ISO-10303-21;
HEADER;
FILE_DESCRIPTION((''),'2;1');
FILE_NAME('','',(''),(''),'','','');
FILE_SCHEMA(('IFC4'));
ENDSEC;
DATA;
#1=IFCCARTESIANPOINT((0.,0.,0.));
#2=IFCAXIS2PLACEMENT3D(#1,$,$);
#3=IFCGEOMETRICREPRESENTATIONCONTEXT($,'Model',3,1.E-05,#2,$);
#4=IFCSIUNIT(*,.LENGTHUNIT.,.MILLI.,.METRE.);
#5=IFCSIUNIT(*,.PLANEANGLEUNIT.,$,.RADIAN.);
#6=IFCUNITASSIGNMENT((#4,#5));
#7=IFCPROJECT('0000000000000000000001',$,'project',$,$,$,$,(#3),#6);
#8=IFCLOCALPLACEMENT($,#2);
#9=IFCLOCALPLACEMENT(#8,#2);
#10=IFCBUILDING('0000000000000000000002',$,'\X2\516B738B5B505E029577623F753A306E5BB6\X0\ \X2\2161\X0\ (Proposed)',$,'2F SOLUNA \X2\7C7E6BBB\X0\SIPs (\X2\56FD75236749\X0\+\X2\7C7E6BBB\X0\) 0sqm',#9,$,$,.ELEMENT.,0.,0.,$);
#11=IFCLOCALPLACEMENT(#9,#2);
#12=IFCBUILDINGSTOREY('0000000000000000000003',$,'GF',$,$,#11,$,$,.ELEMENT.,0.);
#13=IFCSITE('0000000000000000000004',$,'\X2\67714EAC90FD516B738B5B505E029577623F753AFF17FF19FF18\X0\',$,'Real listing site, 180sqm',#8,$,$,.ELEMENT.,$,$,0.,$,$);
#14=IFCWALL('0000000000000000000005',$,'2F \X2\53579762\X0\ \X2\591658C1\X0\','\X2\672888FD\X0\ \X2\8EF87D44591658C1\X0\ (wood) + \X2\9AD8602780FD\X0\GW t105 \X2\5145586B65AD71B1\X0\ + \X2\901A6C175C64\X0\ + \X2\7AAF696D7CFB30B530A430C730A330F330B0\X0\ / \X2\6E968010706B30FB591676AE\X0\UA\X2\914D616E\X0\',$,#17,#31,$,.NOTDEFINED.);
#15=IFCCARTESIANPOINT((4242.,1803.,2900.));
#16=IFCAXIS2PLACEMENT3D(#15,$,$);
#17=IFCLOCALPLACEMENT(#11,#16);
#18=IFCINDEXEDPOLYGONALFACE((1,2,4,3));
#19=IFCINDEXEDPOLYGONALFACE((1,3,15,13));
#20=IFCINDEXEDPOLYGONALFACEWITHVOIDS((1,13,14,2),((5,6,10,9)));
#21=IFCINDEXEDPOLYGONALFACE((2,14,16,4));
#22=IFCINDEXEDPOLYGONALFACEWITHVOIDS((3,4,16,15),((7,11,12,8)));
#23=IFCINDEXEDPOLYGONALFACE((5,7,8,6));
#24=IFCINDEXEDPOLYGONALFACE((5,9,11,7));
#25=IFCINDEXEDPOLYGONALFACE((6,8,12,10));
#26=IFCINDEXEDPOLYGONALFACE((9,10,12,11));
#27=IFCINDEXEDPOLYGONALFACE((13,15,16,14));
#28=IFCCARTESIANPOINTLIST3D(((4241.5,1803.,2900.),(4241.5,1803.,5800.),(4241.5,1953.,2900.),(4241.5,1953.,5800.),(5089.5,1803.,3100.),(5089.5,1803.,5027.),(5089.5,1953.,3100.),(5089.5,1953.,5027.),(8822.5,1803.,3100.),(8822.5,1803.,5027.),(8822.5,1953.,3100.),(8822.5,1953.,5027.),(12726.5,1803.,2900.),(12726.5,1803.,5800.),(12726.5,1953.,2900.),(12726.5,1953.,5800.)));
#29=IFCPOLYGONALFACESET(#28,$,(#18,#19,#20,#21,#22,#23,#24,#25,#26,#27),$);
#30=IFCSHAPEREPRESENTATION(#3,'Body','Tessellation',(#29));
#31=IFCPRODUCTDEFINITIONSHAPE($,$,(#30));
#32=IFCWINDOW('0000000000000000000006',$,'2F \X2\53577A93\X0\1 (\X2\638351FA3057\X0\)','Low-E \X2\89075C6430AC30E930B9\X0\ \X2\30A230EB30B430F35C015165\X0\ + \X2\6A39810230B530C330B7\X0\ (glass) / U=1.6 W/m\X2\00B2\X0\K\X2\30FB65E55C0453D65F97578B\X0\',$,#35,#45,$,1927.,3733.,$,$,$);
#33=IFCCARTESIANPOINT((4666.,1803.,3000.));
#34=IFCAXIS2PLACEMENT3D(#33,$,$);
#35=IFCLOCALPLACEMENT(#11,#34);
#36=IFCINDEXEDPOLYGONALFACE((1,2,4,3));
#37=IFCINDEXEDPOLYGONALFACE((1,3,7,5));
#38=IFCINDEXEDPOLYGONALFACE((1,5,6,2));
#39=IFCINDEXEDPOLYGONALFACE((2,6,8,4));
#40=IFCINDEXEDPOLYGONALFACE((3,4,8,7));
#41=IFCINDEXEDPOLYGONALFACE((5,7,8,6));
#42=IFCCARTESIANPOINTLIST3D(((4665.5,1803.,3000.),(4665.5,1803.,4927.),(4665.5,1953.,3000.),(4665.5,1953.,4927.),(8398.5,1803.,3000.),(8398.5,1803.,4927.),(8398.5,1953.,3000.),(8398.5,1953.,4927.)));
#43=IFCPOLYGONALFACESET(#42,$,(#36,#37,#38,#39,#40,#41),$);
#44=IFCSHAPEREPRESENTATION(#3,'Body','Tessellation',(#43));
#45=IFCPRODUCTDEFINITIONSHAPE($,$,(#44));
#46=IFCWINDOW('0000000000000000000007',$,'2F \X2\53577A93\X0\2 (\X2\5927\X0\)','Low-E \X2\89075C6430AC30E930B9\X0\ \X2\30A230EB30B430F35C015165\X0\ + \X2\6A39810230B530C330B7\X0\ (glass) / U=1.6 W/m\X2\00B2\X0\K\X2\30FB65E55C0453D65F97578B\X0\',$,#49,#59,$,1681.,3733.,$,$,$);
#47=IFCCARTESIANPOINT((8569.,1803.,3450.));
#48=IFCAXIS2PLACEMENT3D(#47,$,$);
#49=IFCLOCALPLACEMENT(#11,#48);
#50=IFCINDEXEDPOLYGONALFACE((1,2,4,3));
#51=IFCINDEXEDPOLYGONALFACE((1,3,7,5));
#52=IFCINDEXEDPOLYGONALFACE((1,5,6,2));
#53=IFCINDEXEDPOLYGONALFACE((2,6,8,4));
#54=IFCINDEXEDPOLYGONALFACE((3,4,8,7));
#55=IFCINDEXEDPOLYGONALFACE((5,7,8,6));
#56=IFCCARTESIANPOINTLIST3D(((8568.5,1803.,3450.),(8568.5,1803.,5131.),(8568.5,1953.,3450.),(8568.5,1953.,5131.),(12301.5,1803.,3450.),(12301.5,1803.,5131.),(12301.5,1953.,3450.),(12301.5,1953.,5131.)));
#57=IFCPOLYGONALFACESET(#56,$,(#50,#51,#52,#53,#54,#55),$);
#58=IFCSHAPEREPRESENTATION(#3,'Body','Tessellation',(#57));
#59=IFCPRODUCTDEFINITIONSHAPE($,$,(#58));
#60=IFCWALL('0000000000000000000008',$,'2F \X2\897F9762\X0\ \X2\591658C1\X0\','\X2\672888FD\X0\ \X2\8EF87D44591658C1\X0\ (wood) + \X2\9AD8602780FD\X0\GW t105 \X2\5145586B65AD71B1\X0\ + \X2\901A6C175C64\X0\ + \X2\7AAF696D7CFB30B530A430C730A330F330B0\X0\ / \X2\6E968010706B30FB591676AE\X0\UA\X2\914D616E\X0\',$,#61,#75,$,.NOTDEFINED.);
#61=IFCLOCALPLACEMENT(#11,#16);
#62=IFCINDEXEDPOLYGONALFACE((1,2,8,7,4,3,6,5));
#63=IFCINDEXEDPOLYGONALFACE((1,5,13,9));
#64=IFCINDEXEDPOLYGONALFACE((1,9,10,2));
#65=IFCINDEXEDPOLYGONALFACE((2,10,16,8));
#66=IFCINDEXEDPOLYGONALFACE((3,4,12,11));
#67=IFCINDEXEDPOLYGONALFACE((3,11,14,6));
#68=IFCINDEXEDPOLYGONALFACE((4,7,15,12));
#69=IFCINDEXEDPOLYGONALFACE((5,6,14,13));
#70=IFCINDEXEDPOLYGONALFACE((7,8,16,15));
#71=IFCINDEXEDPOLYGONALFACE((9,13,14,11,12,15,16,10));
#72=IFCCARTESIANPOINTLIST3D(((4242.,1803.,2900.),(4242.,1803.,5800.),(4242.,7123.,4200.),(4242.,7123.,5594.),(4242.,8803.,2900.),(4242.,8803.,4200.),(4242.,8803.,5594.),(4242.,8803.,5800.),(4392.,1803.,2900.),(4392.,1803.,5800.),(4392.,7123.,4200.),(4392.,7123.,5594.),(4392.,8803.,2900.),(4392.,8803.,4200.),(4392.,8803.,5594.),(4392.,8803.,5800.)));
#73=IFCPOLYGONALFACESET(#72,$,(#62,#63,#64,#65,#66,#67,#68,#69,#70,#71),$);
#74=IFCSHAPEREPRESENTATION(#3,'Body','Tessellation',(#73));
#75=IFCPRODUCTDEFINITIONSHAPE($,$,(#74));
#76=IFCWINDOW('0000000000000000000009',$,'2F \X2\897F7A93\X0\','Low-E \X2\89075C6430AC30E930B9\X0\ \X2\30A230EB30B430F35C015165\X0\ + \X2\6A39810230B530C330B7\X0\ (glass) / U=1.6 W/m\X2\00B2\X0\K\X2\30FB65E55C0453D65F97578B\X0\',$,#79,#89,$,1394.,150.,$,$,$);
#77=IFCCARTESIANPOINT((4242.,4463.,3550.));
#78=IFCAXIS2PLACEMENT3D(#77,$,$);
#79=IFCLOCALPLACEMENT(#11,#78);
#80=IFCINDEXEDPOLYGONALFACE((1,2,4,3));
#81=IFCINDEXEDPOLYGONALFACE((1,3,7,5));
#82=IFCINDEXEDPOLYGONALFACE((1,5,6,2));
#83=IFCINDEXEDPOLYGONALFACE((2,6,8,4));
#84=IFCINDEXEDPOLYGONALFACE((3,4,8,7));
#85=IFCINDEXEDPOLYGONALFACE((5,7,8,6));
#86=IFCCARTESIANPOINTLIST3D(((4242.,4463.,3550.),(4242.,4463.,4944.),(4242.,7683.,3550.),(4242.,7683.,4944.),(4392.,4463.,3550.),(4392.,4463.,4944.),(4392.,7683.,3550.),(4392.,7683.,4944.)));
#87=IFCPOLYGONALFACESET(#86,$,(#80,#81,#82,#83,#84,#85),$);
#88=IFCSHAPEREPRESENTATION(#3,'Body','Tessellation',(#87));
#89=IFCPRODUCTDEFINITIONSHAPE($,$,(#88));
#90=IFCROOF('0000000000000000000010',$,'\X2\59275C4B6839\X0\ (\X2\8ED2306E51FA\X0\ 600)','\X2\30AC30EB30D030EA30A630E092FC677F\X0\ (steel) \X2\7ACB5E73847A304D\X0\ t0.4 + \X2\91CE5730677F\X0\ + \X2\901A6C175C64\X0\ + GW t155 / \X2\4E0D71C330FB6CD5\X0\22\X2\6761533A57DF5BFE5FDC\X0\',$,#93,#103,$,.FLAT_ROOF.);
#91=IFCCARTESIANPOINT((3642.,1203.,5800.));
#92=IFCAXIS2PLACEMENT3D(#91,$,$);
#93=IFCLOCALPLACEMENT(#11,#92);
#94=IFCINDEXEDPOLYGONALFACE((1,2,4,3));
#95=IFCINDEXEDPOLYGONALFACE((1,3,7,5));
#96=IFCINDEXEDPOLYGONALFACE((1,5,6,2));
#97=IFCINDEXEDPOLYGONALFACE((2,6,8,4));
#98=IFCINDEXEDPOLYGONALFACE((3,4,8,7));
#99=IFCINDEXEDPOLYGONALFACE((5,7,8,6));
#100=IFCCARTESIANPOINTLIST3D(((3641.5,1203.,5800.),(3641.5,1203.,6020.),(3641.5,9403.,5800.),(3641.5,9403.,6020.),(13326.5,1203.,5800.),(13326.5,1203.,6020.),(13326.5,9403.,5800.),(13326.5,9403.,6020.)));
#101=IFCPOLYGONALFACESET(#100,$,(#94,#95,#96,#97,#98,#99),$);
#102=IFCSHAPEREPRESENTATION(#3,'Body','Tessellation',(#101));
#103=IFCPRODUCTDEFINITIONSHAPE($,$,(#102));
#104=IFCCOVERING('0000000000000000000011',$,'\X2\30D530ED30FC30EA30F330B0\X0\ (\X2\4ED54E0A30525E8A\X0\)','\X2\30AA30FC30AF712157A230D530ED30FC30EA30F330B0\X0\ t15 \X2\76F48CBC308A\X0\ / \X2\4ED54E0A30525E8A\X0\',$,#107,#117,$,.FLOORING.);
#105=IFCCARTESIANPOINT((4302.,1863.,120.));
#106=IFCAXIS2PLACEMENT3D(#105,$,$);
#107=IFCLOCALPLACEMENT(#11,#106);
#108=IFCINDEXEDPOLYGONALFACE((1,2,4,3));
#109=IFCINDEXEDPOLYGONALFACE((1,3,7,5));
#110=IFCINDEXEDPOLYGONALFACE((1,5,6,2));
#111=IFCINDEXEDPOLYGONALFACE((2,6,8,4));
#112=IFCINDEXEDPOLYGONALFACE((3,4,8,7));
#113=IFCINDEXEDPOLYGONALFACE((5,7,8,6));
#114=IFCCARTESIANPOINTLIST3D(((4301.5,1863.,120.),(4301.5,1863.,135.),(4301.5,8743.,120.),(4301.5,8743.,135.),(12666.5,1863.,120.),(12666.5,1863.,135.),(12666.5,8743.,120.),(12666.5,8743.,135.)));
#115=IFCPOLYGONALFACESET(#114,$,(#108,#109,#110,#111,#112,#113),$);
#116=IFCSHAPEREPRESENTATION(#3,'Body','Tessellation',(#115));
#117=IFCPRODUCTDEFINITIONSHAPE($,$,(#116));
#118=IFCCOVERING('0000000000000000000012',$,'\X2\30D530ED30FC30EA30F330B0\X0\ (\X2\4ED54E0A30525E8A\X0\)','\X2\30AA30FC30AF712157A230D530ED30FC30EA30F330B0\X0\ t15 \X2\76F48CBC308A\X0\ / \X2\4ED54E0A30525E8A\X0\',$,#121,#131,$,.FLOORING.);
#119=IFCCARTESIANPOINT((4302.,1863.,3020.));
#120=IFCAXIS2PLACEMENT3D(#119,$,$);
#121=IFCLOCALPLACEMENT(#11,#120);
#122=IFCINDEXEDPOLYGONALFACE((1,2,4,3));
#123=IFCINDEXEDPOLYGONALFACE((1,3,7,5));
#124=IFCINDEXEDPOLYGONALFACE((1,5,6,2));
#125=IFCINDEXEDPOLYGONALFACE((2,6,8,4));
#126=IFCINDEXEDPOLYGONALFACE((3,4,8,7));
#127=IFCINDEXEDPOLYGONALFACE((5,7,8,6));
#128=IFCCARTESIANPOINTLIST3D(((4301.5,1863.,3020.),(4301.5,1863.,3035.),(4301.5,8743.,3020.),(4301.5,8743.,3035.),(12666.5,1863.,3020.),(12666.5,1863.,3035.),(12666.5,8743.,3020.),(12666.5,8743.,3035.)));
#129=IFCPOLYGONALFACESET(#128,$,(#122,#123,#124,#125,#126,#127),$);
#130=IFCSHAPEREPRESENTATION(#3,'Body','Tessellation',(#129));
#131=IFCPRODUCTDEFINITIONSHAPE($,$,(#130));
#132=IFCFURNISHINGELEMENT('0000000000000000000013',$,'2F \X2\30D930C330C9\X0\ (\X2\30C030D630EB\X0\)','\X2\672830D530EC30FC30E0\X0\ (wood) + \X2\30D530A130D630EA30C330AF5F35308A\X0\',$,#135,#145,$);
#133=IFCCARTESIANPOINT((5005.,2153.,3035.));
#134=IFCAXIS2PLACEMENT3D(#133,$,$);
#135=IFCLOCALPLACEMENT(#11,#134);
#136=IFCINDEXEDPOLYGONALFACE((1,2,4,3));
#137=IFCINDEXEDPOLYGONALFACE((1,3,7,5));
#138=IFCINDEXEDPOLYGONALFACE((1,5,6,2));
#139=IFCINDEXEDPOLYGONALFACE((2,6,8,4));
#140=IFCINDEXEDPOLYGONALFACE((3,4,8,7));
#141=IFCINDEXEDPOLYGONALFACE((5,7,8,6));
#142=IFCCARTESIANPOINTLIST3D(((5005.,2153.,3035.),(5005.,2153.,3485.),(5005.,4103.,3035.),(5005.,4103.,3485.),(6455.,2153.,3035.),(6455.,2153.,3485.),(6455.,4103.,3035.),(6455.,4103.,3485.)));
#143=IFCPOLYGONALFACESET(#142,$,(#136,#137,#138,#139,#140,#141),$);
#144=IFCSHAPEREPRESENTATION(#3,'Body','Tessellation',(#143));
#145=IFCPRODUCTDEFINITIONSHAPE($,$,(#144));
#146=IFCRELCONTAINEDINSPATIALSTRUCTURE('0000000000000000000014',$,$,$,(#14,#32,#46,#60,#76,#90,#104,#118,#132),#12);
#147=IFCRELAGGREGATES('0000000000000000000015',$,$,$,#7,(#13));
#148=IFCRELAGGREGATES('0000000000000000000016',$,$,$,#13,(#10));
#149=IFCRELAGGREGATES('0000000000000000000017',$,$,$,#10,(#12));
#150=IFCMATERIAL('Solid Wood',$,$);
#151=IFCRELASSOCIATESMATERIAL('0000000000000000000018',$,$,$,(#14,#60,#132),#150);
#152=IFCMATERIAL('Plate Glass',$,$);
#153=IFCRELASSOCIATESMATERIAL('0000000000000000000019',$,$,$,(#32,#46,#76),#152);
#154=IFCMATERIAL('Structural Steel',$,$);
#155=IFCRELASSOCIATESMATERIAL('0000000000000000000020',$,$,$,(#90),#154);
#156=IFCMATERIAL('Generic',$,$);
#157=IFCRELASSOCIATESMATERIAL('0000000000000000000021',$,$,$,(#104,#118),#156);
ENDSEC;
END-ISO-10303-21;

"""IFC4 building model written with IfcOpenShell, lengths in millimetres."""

from ifc_helpers import new_model, si_unit, frame, frame_2d, origin, place, context, project, spatial, rectangle, extrude, material, element, fill, save


model = new_model("IFC4")

# Units and contexts
model_context = context("Model", 3, precision=1e-05, world=origin())
ifc_project = project(units=[si_unit("LENGTHUNIT", "METRE", prefix="MILLI"), si_unit("PLANEANGLEUNIT", "RADIAN")], contexts=[model_context])

# Site, building, storey
site_placement = place(None, origin())
site = spatial("IfcSite", under=ifc_project, at=site_placement, Name="東京都八王子市長房町７９８", ObjectType="Real listing site, 180sqm", CompositionType="ELEMENT", RefElevation=0.0)
building_placement = place(site_placement, origin())
building = spatial("IfcBuilding", under=site, at=building_placement, Name="八王子市長房町の家 Ⅱ (Proposed)", ObjectType="2F SOLUNA 籾殻SIPs (国産杉+籾殻) 0sqm", CompositionType="ELEMENT", ElevationOfRefHeight=0.0, ElevationOfTerrain=0.0)
storey_placement = place(building_placement, origin())
storey = spatial("IfcBuildingStorey", under=building, at=storey_placement, Name="GF", CompositionType="ELEMENT", Elevation=0.0)

# Shared definitions
ifc_material_1 = material(Name="Solid Wood")

# Shared definitions
ifc_material_2 = material(Name="Plate Glass")

# Wall, openings, windows
wall_1_placement = place(storey_placement, frame((4242.0, 1803.0, 2900.0)))
wall_1 = element("IfcWall", 1, at=wall_1_placement, inside=storey, material=ifc_material_1, Name="2F 南面 外壁", Description="木製 軸組外壁 (wood) + 高性能GW t105 充填断熱 + 通気層 + 窯業系サイディング / 準耐火・外皮UA配慮", PredefinedType="NOTDEFINED", context=model_context, shape_type="SweptSolid", body=[
    extrude(rectangle(XDim=8485.0, YDim=150.0, at=frame_2d((4242.0, 75.0))), frame((4242.0, 1803.0, 2900.0)), (0.0, 0.0, 1.0), 2900.0),
])
opening_1_placement = place(storey_placement, frame((4666.0, 1803.0, 3000.0)))
opening_1 = element("IfcOpeningElement", 2, at=opening_1_placement, cuts=wall_1, PredefinedType="NOTDEFINED", context=model_context, shape_type="SweptSolid", body=[
    extrude(rectangle(XDim=3733.0, YDim=150.0, at=frame_2d((1866.0, 75.0))), frame((4666.0, 1803.0, 3000.0)), (0.0, 0.0, 1.0), 1927.0),
])
opening_2_placement = place(storey_placement, frame((8569.0, 1803.0, 3450.0)))
opening_2 = element("IfcOpeningElement", 3, at=opening_2_placement, cuts=wall_1, PredefinedType="NOTDEFINED", context=model_context, shape_type="SweptSolid", body=[
    extrude(rectangle(XDim=3733.0, YDim=150.0, at=frame_2d((1866.0, 75.0))), frame((8569.0, 1803.0, 3450.0)), (0.0, 0.0, 1.0), 1681.0),
])
window_1_placement = place(storey_placement, frame((4666.0, 1803.0, 3000.0)))
window_1 = element("IfcWindow", 4, at=window_1_placement, inside=storey, material=ifc_material_2, Name="2F 南窓1 (掃出し)", Description="Low-E 複層ガラス アルゴン封入 + 樹脂サッシ (glass) / U=1.6 W/m²K・日射取得型", OverallHeight=1927.0, OverallWidth=3733.0, context=model_context, shape_type="SweptSolid", body=[
    extrude(rectangle(XDim=3733.0, YDim=150.0, at=frame_2d((1866.0, 75.0))), frame((4666.0, 1803.0, 3000.0)), (0.0, 0.0, 1.0), 1927.0),
])
fill(opening_1, window_1)
window_2_placement = place(storey_placement, frame((8569.0, 1803.0, 3450.0)))
window_2 = element("IfcWindow", 5, at=window_2_placement, inside=storey, material=ifc_material_2, Name="2F 南窓2 (大)", Description="Low-E 複層ガラス アルゴン封入 + 樹脂サッシ (glass) / U=1.6 W/m²K・日射取得型", OverallHeight=1681.0, OverallWidth=3733.0, context=model_context, shape_type="SweptSolid", body=[
    extrude(rectangle(XDim=3733.0, YDim=150.0, at=frame_2d((1866.0, 75.0))), frame((8569.0, 1803.0, 3450.0)), (0.0, 0.0, 1.0), 1681.0),
])
fill(opening_2, window_2)

# Wall, opening, window
wall_2_placement = place(storey_placement, frame((4242.0, 1803.0, 2900.0)))
wall_2 = element("IfcWall", 6, at=wall_2_placement, inside=storey, material=ifc_material_1, Name="2F 西面 外壁", Description="木製 軸組外壁 (wood) + 高性能GW t105 充填断熱 + 通気層 + 窯業系サイディング / 準耐火・外皮UA配慮", PredefinedType="NOTDEFINED", context=model_context, shape_type="SweptSolid", body=[
    extrude(rectangle(XDim=150.0, YDim=7000.0, at=frame_2d((75.0, 3500.0))), frame((4242.0, 1803.0, 2900.0)), (0.0, 0.0, 1.0), 2900.0),
])
opening_3_placement = place(storey_placement, frame((4242.0, 4463.0, 3550.0)))
opening_3 = element("IfcOpeningElement", 7, at=opening_3_placement, cuts=wall_2, PredefinedType="NOTDEFINED", context=model_context, shape_type="SweptSolid", body=[
    extrude(rectangle(XDim=150.0, YDim=3220.0, at=frame_2d((75.0, 1610.0))), frame((4242.0, 4463.0, 3550.0)), (0.0, 0.0, 1.0), 1394.0),
])
window_3_placement = place(storey_placement, frame((4242.0, 4463.0, 3550.0)))
window_3 = element("IfcWindow", 8, at=window_3_placement, inside=storey, material=ifc_material_2, Name="2F 西窓", Description="Low-E 複層ガラス アルゴン封入 + 樹脂サッシ (glass) / U=1.6 W/m²K・日射取得型", OverallHeight=1394.0, OverallWidth=150.0, context=model_context, shape_type="SweptSolid", body=[
    extrude(rectangle(XDim=150.0, YDim=3220.0, at=frame_2d((75.0, 1610.0))), frame((4242.0, 4463.0, 3550.0)), (0.0, 0.0, 1.0), 1394.0),
])
fill(opening_3, window_3)

# Roof
ifc_material_3 = material(Name="Structural Steel")
roof_placement = place(storey_placement, frame((3642.0, 1203.0, 5800.0)))
element("IfcRoof", 9, at=roof_placement, inside=storey, material=ifc_material_3, Name="大屋根 (軒の出 600)", Description="ガルバリウム鋼板 (steel) 立平葺き t0.4 + 野地板 + 通気層 + GW t155 / 不燃・法22条区域対応", PredefinedType="FLAT_ROOF", context=model_context, shape_type="SweptSolid", body=[
    extrude(rectangle(XDim=9685.0, YDim=8200.0, at=frame_2d((4842.0, 4100.0))), frame((3642.0, 1203.0, 5800.0)), (0.0, 0.0, 1.0), 220.0),
])

# Coverings
ifc_material_4 = material(Name="Generic")
covering_1_placement = place(storey_placement, frame((4302.0, 1863.0, 120.0)))
element("IfcCovering", 10, at=covering_1_placement, inside=storey, material=ifc_material_4, Name="フローリング (仕上げ床)", Description="オーク無垢フローリング t15 直貼り / 仕上げ床", PredefinedType="FLOORING", context=model_context, shape_type="SweptSolid", body=[
    extrude(rectangle(XDim=8365.0, YDim=6880.0, at=frame_2d((4182.0, 3440.0))), frame((4302.0, 1863.0, 120.0)), (0.0, 0.0, 1.0), 15.0),
])
covering_2_placement = place(storey_placement, frame((4302.0, 1863.0, 3020.0)))
element("IfcCovering", 11, at=covering_2_placement, inside=storey, material=ifc_material_4, Name="フローリング (仕上げ床)", Description="オーク無垢フローリング t15 直貼り / 仕上げ床", PredefinedType="FLOORING", context=model_context, shape_type="SweptSolid", body=[
    extrude(rectangle(XDim=8365.0, YDim=6880.0, at=frame_2d((4182.0, 3440.0))), frame((4302.0, 1863.0, 3020.0)), (0.0, 0.0, 1.0), 15.0),
])

# Furnishing element
furnishing_placement = place(storey_placement, frame((5005.0, 2153.0, 3035.0)))
element("IfcFurnishingElement", 12, at=furnishing_placement, inside=storey, material=ifc_material_1, Name="2F ベッド (ダブル)", Description="木フレーム (wood) + ファブリック張り", context=model_context, shape_type="SweptSolid", body=[
    extrude(rectangle(XDim=1450.0, YDim=1950.0, at=frame_2d((725.0, 975.0))), frame((5005.0, 2153.0, 3035.0)), (0.0, 0.0, 1.0), 450.0),
])

save(model, "model.ifc")
